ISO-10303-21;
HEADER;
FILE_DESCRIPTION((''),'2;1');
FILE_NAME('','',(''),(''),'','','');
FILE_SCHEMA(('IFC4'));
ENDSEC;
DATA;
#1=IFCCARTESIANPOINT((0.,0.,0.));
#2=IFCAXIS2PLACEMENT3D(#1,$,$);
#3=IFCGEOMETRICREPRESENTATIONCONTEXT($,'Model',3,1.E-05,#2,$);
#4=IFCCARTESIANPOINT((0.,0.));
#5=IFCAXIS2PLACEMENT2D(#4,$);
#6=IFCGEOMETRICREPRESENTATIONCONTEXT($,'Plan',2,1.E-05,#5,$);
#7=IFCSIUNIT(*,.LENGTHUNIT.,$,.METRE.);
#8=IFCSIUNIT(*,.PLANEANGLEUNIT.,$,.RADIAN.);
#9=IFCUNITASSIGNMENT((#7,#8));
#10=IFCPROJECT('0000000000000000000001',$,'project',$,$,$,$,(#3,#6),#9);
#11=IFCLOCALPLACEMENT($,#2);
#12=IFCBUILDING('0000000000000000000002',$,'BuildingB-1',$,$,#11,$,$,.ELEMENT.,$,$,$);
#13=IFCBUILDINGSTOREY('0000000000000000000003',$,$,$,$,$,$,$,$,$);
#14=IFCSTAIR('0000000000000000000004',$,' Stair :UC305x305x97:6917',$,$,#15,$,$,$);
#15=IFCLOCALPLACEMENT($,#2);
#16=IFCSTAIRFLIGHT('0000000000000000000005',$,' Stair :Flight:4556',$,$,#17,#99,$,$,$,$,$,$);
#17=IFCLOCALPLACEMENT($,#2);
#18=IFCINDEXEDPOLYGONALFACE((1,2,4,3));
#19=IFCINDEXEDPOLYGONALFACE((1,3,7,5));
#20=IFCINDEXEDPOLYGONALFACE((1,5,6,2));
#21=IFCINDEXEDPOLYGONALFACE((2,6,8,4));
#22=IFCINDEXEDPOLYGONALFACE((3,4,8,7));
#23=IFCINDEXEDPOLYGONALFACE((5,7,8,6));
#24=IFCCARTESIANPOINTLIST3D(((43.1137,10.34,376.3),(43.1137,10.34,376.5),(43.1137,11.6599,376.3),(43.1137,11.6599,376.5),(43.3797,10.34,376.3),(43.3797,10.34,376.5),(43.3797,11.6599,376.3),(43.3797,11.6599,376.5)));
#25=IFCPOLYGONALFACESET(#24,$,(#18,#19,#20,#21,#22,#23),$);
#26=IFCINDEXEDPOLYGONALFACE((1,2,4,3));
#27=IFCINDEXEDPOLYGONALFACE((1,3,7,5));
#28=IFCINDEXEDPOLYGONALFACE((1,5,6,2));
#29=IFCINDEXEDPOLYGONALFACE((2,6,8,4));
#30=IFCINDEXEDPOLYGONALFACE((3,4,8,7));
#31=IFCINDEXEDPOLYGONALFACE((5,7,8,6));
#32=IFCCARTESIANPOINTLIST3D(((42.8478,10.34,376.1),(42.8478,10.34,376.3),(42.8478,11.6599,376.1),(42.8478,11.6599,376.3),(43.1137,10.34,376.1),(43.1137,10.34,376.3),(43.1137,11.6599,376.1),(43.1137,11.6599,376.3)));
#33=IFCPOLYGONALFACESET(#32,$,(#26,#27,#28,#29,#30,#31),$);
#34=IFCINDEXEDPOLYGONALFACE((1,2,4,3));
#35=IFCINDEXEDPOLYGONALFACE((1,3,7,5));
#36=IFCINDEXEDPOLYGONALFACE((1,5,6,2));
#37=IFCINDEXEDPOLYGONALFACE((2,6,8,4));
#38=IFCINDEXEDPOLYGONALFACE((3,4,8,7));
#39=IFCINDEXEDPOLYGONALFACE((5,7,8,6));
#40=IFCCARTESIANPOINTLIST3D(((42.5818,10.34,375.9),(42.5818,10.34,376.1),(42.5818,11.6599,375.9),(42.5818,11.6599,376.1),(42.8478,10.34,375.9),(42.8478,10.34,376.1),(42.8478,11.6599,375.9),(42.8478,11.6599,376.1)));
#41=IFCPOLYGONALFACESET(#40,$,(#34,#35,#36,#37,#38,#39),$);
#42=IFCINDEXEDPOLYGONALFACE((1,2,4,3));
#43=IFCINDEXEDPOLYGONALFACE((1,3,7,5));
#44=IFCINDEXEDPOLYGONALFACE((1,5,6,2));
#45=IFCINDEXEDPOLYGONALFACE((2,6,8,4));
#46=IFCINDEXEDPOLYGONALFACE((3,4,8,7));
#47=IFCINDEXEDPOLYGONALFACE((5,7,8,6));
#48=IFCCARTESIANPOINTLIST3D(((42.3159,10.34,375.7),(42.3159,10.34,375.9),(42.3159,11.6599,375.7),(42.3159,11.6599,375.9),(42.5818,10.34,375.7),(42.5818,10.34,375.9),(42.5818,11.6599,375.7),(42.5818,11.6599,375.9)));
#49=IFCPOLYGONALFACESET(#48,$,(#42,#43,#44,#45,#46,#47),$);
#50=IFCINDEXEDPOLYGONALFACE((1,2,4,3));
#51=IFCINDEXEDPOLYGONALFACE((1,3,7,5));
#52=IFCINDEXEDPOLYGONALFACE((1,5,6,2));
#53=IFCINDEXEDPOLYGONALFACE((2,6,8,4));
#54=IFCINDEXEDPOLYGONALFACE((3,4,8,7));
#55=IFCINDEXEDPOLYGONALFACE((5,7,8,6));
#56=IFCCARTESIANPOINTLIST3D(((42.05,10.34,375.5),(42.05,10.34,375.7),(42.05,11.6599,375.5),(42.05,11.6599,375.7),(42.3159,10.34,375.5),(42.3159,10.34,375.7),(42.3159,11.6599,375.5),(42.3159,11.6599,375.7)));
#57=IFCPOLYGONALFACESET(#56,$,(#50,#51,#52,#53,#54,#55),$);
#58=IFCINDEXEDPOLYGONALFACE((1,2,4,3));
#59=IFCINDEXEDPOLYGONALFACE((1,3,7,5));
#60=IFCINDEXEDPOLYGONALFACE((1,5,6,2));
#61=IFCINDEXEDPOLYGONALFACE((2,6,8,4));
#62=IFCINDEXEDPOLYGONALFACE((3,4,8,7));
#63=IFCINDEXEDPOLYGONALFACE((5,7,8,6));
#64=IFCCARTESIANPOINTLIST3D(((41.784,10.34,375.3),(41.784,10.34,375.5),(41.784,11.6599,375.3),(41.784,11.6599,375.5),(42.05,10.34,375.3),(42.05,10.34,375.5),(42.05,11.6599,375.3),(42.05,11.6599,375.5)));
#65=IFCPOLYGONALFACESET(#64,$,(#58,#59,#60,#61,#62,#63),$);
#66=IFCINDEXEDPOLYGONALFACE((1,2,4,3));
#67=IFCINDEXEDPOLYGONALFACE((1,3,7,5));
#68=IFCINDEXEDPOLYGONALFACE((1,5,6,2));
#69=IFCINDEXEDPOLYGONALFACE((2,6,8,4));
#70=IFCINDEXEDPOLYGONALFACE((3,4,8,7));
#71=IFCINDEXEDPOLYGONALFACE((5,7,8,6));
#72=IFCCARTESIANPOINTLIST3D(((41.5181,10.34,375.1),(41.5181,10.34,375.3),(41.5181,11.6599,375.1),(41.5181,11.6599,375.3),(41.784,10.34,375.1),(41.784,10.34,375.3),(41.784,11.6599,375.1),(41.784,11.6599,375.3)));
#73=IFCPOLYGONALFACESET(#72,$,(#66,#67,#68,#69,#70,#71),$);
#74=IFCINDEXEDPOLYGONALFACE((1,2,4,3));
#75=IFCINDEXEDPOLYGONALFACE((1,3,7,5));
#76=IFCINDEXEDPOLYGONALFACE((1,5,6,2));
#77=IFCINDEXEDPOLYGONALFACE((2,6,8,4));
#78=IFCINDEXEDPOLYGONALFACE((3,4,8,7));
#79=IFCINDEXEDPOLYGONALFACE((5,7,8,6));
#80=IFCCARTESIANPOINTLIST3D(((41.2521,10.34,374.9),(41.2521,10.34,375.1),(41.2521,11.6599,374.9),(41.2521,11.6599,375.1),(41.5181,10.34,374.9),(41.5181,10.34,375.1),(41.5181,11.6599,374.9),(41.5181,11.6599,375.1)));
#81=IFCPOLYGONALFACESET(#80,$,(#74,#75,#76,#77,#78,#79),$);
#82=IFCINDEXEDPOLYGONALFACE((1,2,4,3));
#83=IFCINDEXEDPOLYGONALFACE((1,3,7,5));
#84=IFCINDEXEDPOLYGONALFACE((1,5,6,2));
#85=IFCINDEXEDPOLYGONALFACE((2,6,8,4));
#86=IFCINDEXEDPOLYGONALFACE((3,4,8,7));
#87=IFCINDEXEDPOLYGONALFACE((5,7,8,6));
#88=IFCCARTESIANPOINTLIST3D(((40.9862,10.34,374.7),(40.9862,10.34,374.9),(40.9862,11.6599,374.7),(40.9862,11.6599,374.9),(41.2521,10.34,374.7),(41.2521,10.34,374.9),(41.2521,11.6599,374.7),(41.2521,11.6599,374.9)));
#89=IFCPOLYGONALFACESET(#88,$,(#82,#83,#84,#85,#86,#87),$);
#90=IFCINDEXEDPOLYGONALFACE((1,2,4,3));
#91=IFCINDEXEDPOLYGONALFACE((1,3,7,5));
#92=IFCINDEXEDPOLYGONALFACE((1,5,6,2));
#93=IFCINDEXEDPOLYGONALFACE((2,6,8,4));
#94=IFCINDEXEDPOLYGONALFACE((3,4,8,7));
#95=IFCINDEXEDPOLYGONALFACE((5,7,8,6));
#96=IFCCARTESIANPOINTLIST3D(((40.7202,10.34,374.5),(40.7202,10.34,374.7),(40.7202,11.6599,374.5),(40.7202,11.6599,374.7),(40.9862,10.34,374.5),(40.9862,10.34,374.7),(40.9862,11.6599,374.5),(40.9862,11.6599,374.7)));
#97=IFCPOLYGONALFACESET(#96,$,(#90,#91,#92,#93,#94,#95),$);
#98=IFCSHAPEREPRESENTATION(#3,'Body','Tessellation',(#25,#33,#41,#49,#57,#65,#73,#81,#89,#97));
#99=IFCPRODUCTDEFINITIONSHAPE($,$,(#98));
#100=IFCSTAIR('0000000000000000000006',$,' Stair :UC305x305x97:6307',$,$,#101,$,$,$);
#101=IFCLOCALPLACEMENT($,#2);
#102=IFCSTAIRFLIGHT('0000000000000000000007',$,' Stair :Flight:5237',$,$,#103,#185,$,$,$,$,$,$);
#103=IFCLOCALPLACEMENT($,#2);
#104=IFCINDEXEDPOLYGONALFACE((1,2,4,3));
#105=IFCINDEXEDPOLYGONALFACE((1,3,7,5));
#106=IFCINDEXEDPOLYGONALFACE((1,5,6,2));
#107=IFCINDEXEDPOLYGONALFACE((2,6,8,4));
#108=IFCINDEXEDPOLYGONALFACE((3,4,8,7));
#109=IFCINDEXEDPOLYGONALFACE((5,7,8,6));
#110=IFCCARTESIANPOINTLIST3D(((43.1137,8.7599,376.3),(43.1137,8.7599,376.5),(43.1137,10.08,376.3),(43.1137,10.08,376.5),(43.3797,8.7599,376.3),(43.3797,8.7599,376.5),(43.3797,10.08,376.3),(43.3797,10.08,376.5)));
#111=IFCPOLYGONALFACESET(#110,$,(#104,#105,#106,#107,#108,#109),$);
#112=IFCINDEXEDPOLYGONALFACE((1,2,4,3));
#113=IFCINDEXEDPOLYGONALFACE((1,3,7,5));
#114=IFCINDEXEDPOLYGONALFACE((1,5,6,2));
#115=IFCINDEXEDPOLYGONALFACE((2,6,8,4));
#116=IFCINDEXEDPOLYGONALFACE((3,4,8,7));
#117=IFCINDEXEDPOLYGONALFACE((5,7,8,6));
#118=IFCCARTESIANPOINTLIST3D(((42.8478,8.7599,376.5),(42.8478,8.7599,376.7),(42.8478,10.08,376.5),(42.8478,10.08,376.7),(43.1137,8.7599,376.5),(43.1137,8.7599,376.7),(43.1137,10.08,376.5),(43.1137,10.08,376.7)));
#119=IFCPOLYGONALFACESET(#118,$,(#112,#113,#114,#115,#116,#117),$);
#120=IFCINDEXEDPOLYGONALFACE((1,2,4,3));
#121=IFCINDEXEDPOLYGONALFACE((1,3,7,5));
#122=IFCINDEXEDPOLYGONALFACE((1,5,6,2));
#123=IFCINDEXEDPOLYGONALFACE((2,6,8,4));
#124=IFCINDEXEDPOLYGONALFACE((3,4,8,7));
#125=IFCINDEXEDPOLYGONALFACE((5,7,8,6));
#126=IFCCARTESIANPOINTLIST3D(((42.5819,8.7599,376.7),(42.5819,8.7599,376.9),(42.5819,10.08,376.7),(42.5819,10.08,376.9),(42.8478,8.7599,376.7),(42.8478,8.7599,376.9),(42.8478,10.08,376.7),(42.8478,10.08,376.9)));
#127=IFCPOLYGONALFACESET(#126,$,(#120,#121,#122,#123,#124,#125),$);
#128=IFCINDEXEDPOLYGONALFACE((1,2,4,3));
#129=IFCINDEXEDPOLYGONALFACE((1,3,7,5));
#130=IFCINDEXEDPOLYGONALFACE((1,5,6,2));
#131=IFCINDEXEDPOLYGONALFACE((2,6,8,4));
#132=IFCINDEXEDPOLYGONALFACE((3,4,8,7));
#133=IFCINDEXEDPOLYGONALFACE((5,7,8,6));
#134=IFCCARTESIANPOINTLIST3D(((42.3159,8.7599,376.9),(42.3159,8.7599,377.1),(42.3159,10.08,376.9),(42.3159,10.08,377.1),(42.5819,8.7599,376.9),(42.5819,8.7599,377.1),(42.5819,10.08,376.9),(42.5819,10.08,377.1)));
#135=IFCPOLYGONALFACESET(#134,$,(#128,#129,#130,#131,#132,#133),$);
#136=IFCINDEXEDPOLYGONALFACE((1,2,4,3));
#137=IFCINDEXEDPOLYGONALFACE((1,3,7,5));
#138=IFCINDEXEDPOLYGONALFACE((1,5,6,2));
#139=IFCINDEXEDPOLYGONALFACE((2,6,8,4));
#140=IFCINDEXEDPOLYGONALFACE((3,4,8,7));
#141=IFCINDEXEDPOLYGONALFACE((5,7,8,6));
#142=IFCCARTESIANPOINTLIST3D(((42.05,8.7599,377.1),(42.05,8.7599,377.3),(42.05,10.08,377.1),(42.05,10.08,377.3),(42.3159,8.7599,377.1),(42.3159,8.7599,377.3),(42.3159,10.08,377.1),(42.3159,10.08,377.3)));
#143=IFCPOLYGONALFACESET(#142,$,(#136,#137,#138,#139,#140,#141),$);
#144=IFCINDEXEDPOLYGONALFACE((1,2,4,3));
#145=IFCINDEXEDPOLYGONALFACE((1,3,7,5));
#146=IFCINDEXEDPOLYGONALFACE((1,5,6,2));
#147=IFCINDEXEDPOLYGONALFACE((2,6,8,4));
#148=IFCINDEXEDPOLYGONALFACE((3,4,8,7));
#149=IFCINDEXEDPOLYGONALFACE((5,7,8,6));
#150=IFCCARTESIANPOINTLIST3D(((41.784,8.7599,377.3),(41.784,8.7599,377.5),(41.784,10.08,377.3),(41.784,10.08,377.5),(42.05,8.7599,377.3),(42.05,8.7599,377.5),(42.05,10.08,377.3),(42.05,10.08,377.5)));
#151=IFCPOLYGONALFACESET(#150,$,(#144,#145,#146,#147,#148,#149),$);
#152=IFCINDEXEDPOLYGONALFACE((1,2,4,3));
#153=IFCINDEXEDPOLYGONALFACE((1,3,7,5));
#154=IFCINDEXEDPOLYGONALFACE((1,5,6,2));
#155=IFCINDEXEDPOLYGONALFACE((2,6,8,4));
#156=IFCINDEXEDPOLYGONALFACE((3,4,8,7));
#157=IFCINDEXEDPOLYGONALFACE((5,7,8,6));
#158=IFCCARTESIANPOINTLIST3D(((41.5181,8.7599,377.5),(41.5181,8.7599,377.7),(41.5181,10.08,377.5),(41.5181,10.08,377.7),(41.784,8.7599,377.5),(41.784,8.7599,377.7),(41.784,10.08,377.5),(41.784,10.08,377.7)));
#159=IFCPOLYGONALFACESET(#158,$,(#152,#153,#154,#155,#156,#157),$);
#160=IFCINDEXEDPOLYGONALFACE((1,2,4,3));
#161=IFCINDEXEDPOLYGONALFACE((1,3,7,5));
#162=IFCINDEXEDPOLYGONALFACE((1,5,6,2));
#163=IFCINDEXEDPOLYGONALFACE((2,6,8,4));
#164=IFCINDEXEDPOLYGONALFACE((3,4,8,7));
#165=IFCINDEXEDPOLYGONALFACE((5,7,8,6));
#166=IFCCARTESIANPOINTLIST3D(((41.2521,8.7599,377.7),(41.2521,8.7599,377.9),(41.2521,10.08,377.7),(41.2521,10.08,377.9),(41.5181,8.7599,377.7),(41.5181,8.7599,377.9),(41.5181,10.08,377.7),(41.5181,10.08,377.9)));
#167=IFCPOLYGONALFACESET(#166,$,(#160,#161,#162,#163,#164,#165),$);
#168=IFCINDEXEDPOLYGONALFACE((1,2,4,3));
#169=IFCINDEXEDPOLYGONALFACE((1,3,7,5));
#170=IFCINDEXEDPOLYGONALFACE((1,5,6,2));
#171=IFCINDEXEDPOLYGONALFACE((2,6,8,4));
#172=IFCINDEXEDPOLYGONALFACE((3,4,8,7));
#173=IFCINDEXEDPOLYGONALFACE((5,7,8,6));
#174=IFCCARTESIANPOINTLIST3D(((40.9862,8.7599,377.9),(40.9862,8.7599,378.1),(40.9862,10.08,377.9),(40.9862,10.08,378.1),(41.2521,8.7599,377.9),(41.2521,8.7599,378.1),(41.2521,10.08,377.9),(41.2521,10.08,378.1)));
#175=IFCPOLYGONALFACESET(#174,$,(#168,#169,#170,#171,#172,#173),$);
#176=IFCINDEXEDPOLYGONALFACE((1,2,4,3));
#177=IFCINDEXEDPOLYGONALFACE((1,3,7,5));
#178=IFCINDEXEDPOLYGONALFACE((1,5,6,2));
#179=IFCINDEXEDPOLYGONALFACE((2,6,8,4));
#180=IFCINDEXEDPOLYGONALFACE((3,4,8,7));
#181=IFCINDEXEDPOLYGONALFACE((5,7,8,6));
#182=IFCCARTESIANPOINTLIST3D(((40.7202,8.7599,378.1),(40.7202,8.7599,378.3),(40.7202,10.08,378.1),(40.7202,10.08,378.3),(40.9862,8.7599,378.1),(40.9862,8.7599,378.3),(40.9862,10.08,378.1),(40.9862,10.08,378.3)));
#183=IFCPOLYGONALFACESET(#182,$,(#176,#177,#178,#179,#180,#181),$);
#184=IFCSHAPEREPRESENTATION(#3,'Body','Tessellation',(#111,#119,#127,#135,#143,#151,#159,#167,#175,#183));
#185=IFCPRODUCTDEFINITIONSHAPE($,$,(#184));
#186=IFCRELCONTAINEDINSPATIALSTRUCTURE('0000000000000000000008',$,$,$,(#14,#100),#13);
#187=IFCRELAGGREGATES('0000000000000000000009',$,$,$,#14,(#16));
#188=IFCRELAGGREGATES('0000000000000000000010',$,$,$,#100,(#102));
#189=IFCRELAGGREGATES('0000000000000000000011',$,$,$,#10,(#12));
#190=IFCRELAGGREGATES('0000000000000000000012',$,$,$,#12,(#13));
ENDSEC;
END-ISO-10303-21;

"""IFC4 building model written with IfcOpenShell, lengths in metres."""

from ifc_helpers import new_model, si_unit, frame, origin, origin_2d, place, context, project, spatial, polyline, outline, extrude, element, aggregate, save


model = new_model("IFC4")

# Units and contexts
model_context = context("Model", 3, precision=1e-05, world=origin())
plan_context = context("Plan", 2, precision=1e-05, world=origin_2d())
ifc_project = project(units=[si_unit("LENGTHUNIT", "METRE"), si_unit("PLANEANGLEUNIT", "RADIAN")], contexts=[model_context, plan_context])

# Building, storey
building_placement = place(None, origin())
building = spatial("IfcBuilding", under=ifc_project, at=building_placement, Name="BuildingB-1", CompositionType="ELEMENT")
storey = spatial("IfcBuildingStorey", under=building)

# Stairs, stair flights
stair_1 = element("IfcStair", 1, inside=storey, Name=" Stair :UC305x305x97:6917")
stair_flight_1 = element("IfcStairFlight", 2, Name=" Stair :Flight:4556", context=model_context, shape_type="SweptSolid", body=[
    extrude(outline(polyline([(43.1137, 11.6599, 376.5), (43.1137, 10.34, 376.5), (43.3797, 10.34, 376.5), (43.3797, 11.6599, 376.5), (43.1137, 11.6599, 376.5)])), origin(), (0.0, 0.0, -1.0), 0.2),
    extrude(outline(polyline([(42.8478, 11.6599, 376.5), (42.8478, 10.34, 376.5), (43.1137, 10.34, 376.5), (43.1137, 11.6599, 376.5), (42.8478, 11.6599, 376.5)])), frame((0.0, 0.0, -0.2)), (0.0, 0.0, -1.0), 0.2),
    extrude(outline(polyline([(42.5818, 11.6599, 376.5), (42.5818, 10.34, 376.5), (42.8478, 10.34, 376.5), (42.8478, 11.6599, 376.5), (42.5818, 11.6599, 376.5)])), frame((0.0, 0.0, -0.4)), (0.0, 0.0, -1.0), 0.2),
    extrude(outline(polyline([(42.3159, 11.6599, 376.5), (42.3159, 10.34, 376.5), (42.5818, 10.34, 376.5), (42.5818, 11.6599, 376.5), (42.3159, 11.6599, 376.5)])), frame((0.0, 0.0, -0.6)), (0.0, 0.0, -1.0), 0.2),
    extrude(outline(polyline([(42.05, 11.6599, 376.5), (42.05, 10.34, 376.5), (42.3159, 10.34, 376.5), (42.3159, 11.6599, 376.5), (42.05, 11.6599, 376.5)])), frame((0.0, 0.0, -0.8)), (0.0, 0.0, -1.0), 0.2),
    extrude(outline(polyline([(41.784, 11.6599, 376.5), (41.784, 10.34, 376.5), (42.05, 10.34, 376.5), (42.05, 11.6599, 376.5), (41.784, 11.6599, 376.5)])), frame((0.0, 0.0, -1.0)), (0.0, 0.0, -1.0), 0.2),
    extrude(outline(polyline([(41.5181, 11.6599, 376.5), (41.5181, 10.34, 376.5), (41.784, 10.34, 376.5), (41.784, 11.6599, 376.5), (41.5181, 11.6599, 376.5)])), frame((0.0, 0.0, -1.2)), (0.0, 0.0, -1.0), 0.2),
    extrude(outline(polyline([(41.2521, 11.6599, 376.5), (41.2521, 10.34, 376.5), (41.5181, 10.34, 376.5), (41.5181, 11.6599, 376.5), (41.2521, 11.6599, 376.5)])), frame((0.0, 0.0, -1.4)), (0.0, 0.0, -1.0), 0.2),
    extrude(outline(polyline([(40.9862, 11.6599, 376.5), (40.9862, 10.34, 376.5), (41.2521, 10.34, 376.5), (41.2521, 11.6599, 376.5), (40.9862, 11.6599, 376.5)])), frame((0.0, 0.0, -1.6)), (0.0, 0.0, -1.0), 0.2),
    extrude(outline(polyline([(40.7202, 11.6599, 376.5), (40.7202, 10.34, 376.5), (40.9862, 10.34, 376.5), (40.9862, 11.6599, 376.5), (40.7202, 11.6599, 376.5)])), frame((0.0, 0.0, -1.8)), (0.0, 0.0, -1.0), 0.2),
])
aggregate(stair_1, [stair_flight_1])
stair_2 = element("IfcStair", 3, inside=storey, Name=" Stair :UC305x305x97:6307")
stair_flight_2 = element("IfcStairFlight", 4, Name=" Stair :Flight:5237", context=model_context, shape_type="SweptSolid", body=[
    extrude(outline(polyline([(43.1137, 8.7599, 376.5), (43.1137, 10.08, 376.5), (43.3797, 10.08, 376.5), (43.3797, 8.7599, 376.5), (43.1137, 8.7599, 376.5)])), origin(), (0.0, 0.0, -1.0), 0.2),
    extrude(outline(polyline([(42.8478, 8.7599, 376.5), (42.8478, 10.08, 376.5), (43.1137, 10.08, 376.5), (43.1137, 8.7599, 376.5), (42.8478, 8.7599, 376.5)])), frame((0.0, 0.0, 0.2)), (0.0, 0.0, -1.0), 0.2),
    extrude(outline(polyline([(42.5819, 8.7599, 376.5), (42.5819, 10.08, 376.5), (42.8478, 10.08, 376.5), (42.8478, 8.7599, 376.5), (42.5819, 8.7599, 376.5)])), frame((0.0, 0.0, 0.4)), (0.0, 0.0, -1.0), 0.2),
    extrude(outline(polyline([(42.3159, 8.7599, 376.5), (42.3159, 10.08, 376.5), (42.5819, 10.08, 376.5), (42.5819, 8.7599, 376.5), (42.3159, 8.7599, 376.5)])), frame((0.0, 0.0, 0.6)), (0.0, 0.0, -1.0), 0.2),
    extrude(outline(polyline([(42.05, 8.7599, 376.5), (42.05, 10.08, 376.5), (42.3159, 10.08, 376.5), (42.3159, 8.7599, 376.5), (42.05, 8.7599, 376.5)])), frame((0.0, 0.0, 0.8)), (0.0, 0.0, -1.0), 0.2),
    extrude(outline(polyline([(41.784, 8.7599, 376.5), (41.784, 10.08, 376.5), (42.05, 10.08, 376.5), (42.05, 8.7599, 376.5), (41.784, 8.7599, 376.5)])), frame((0.0, 0.0, 1.0)), (0.0, 0.0, -1.0), 0.2),
    extrude(outline(polyline([(41.5181, 8.7599, 376.5), (41.5181, 10.08, 376.5), (41.784, 10.08, 376.5), (41.784, 8.7599, 376.5), (41.5181, 8.7599, 376.5)])), frame((0.0, 0.0, 1.2)), (0.0, 0.0, -1.0), 0.2),
    extrude(outline(polyline([(41.2521, 8.7599, 376.5), (41.2521, 10.08, 376.5), (41.5181, 10.08, 376.5), (41.5181, 8.7599, 376.5), (41.2521, 8.7599, 376.5)])), frame((0.0, 0.0, 1.4)), (0.0, 0.0, -1.0), 0.2),
    extrude(outline(polyline([(40.9862, 8.7599, 376.5), (40.9862, 10.08, 376.5), (41.2521, 10.08, 376.5), (41.2521, 8.7599, 376.5), (40.9862, 8.7599, 376.5)])), frame((0.0, 0.0, 1.6)), (0.0, 0.0, -1.0), 0.2),
    extrude(outline(polyline([(40.7202, 8.7599, 376.5), (40.7202, 10.08, 376.5), (40.9862, 10.08, 376.5), (40.9862, 8.7599, 376.5), (40.7202, 8.7599, 376.5)])), frame((0.0, 0.0, 1.8)), (0.0, 0.0, -1.0), 0.2),
])
aggregate(stair_2, [stair_flight_2])

save(model, "model.ifc")
